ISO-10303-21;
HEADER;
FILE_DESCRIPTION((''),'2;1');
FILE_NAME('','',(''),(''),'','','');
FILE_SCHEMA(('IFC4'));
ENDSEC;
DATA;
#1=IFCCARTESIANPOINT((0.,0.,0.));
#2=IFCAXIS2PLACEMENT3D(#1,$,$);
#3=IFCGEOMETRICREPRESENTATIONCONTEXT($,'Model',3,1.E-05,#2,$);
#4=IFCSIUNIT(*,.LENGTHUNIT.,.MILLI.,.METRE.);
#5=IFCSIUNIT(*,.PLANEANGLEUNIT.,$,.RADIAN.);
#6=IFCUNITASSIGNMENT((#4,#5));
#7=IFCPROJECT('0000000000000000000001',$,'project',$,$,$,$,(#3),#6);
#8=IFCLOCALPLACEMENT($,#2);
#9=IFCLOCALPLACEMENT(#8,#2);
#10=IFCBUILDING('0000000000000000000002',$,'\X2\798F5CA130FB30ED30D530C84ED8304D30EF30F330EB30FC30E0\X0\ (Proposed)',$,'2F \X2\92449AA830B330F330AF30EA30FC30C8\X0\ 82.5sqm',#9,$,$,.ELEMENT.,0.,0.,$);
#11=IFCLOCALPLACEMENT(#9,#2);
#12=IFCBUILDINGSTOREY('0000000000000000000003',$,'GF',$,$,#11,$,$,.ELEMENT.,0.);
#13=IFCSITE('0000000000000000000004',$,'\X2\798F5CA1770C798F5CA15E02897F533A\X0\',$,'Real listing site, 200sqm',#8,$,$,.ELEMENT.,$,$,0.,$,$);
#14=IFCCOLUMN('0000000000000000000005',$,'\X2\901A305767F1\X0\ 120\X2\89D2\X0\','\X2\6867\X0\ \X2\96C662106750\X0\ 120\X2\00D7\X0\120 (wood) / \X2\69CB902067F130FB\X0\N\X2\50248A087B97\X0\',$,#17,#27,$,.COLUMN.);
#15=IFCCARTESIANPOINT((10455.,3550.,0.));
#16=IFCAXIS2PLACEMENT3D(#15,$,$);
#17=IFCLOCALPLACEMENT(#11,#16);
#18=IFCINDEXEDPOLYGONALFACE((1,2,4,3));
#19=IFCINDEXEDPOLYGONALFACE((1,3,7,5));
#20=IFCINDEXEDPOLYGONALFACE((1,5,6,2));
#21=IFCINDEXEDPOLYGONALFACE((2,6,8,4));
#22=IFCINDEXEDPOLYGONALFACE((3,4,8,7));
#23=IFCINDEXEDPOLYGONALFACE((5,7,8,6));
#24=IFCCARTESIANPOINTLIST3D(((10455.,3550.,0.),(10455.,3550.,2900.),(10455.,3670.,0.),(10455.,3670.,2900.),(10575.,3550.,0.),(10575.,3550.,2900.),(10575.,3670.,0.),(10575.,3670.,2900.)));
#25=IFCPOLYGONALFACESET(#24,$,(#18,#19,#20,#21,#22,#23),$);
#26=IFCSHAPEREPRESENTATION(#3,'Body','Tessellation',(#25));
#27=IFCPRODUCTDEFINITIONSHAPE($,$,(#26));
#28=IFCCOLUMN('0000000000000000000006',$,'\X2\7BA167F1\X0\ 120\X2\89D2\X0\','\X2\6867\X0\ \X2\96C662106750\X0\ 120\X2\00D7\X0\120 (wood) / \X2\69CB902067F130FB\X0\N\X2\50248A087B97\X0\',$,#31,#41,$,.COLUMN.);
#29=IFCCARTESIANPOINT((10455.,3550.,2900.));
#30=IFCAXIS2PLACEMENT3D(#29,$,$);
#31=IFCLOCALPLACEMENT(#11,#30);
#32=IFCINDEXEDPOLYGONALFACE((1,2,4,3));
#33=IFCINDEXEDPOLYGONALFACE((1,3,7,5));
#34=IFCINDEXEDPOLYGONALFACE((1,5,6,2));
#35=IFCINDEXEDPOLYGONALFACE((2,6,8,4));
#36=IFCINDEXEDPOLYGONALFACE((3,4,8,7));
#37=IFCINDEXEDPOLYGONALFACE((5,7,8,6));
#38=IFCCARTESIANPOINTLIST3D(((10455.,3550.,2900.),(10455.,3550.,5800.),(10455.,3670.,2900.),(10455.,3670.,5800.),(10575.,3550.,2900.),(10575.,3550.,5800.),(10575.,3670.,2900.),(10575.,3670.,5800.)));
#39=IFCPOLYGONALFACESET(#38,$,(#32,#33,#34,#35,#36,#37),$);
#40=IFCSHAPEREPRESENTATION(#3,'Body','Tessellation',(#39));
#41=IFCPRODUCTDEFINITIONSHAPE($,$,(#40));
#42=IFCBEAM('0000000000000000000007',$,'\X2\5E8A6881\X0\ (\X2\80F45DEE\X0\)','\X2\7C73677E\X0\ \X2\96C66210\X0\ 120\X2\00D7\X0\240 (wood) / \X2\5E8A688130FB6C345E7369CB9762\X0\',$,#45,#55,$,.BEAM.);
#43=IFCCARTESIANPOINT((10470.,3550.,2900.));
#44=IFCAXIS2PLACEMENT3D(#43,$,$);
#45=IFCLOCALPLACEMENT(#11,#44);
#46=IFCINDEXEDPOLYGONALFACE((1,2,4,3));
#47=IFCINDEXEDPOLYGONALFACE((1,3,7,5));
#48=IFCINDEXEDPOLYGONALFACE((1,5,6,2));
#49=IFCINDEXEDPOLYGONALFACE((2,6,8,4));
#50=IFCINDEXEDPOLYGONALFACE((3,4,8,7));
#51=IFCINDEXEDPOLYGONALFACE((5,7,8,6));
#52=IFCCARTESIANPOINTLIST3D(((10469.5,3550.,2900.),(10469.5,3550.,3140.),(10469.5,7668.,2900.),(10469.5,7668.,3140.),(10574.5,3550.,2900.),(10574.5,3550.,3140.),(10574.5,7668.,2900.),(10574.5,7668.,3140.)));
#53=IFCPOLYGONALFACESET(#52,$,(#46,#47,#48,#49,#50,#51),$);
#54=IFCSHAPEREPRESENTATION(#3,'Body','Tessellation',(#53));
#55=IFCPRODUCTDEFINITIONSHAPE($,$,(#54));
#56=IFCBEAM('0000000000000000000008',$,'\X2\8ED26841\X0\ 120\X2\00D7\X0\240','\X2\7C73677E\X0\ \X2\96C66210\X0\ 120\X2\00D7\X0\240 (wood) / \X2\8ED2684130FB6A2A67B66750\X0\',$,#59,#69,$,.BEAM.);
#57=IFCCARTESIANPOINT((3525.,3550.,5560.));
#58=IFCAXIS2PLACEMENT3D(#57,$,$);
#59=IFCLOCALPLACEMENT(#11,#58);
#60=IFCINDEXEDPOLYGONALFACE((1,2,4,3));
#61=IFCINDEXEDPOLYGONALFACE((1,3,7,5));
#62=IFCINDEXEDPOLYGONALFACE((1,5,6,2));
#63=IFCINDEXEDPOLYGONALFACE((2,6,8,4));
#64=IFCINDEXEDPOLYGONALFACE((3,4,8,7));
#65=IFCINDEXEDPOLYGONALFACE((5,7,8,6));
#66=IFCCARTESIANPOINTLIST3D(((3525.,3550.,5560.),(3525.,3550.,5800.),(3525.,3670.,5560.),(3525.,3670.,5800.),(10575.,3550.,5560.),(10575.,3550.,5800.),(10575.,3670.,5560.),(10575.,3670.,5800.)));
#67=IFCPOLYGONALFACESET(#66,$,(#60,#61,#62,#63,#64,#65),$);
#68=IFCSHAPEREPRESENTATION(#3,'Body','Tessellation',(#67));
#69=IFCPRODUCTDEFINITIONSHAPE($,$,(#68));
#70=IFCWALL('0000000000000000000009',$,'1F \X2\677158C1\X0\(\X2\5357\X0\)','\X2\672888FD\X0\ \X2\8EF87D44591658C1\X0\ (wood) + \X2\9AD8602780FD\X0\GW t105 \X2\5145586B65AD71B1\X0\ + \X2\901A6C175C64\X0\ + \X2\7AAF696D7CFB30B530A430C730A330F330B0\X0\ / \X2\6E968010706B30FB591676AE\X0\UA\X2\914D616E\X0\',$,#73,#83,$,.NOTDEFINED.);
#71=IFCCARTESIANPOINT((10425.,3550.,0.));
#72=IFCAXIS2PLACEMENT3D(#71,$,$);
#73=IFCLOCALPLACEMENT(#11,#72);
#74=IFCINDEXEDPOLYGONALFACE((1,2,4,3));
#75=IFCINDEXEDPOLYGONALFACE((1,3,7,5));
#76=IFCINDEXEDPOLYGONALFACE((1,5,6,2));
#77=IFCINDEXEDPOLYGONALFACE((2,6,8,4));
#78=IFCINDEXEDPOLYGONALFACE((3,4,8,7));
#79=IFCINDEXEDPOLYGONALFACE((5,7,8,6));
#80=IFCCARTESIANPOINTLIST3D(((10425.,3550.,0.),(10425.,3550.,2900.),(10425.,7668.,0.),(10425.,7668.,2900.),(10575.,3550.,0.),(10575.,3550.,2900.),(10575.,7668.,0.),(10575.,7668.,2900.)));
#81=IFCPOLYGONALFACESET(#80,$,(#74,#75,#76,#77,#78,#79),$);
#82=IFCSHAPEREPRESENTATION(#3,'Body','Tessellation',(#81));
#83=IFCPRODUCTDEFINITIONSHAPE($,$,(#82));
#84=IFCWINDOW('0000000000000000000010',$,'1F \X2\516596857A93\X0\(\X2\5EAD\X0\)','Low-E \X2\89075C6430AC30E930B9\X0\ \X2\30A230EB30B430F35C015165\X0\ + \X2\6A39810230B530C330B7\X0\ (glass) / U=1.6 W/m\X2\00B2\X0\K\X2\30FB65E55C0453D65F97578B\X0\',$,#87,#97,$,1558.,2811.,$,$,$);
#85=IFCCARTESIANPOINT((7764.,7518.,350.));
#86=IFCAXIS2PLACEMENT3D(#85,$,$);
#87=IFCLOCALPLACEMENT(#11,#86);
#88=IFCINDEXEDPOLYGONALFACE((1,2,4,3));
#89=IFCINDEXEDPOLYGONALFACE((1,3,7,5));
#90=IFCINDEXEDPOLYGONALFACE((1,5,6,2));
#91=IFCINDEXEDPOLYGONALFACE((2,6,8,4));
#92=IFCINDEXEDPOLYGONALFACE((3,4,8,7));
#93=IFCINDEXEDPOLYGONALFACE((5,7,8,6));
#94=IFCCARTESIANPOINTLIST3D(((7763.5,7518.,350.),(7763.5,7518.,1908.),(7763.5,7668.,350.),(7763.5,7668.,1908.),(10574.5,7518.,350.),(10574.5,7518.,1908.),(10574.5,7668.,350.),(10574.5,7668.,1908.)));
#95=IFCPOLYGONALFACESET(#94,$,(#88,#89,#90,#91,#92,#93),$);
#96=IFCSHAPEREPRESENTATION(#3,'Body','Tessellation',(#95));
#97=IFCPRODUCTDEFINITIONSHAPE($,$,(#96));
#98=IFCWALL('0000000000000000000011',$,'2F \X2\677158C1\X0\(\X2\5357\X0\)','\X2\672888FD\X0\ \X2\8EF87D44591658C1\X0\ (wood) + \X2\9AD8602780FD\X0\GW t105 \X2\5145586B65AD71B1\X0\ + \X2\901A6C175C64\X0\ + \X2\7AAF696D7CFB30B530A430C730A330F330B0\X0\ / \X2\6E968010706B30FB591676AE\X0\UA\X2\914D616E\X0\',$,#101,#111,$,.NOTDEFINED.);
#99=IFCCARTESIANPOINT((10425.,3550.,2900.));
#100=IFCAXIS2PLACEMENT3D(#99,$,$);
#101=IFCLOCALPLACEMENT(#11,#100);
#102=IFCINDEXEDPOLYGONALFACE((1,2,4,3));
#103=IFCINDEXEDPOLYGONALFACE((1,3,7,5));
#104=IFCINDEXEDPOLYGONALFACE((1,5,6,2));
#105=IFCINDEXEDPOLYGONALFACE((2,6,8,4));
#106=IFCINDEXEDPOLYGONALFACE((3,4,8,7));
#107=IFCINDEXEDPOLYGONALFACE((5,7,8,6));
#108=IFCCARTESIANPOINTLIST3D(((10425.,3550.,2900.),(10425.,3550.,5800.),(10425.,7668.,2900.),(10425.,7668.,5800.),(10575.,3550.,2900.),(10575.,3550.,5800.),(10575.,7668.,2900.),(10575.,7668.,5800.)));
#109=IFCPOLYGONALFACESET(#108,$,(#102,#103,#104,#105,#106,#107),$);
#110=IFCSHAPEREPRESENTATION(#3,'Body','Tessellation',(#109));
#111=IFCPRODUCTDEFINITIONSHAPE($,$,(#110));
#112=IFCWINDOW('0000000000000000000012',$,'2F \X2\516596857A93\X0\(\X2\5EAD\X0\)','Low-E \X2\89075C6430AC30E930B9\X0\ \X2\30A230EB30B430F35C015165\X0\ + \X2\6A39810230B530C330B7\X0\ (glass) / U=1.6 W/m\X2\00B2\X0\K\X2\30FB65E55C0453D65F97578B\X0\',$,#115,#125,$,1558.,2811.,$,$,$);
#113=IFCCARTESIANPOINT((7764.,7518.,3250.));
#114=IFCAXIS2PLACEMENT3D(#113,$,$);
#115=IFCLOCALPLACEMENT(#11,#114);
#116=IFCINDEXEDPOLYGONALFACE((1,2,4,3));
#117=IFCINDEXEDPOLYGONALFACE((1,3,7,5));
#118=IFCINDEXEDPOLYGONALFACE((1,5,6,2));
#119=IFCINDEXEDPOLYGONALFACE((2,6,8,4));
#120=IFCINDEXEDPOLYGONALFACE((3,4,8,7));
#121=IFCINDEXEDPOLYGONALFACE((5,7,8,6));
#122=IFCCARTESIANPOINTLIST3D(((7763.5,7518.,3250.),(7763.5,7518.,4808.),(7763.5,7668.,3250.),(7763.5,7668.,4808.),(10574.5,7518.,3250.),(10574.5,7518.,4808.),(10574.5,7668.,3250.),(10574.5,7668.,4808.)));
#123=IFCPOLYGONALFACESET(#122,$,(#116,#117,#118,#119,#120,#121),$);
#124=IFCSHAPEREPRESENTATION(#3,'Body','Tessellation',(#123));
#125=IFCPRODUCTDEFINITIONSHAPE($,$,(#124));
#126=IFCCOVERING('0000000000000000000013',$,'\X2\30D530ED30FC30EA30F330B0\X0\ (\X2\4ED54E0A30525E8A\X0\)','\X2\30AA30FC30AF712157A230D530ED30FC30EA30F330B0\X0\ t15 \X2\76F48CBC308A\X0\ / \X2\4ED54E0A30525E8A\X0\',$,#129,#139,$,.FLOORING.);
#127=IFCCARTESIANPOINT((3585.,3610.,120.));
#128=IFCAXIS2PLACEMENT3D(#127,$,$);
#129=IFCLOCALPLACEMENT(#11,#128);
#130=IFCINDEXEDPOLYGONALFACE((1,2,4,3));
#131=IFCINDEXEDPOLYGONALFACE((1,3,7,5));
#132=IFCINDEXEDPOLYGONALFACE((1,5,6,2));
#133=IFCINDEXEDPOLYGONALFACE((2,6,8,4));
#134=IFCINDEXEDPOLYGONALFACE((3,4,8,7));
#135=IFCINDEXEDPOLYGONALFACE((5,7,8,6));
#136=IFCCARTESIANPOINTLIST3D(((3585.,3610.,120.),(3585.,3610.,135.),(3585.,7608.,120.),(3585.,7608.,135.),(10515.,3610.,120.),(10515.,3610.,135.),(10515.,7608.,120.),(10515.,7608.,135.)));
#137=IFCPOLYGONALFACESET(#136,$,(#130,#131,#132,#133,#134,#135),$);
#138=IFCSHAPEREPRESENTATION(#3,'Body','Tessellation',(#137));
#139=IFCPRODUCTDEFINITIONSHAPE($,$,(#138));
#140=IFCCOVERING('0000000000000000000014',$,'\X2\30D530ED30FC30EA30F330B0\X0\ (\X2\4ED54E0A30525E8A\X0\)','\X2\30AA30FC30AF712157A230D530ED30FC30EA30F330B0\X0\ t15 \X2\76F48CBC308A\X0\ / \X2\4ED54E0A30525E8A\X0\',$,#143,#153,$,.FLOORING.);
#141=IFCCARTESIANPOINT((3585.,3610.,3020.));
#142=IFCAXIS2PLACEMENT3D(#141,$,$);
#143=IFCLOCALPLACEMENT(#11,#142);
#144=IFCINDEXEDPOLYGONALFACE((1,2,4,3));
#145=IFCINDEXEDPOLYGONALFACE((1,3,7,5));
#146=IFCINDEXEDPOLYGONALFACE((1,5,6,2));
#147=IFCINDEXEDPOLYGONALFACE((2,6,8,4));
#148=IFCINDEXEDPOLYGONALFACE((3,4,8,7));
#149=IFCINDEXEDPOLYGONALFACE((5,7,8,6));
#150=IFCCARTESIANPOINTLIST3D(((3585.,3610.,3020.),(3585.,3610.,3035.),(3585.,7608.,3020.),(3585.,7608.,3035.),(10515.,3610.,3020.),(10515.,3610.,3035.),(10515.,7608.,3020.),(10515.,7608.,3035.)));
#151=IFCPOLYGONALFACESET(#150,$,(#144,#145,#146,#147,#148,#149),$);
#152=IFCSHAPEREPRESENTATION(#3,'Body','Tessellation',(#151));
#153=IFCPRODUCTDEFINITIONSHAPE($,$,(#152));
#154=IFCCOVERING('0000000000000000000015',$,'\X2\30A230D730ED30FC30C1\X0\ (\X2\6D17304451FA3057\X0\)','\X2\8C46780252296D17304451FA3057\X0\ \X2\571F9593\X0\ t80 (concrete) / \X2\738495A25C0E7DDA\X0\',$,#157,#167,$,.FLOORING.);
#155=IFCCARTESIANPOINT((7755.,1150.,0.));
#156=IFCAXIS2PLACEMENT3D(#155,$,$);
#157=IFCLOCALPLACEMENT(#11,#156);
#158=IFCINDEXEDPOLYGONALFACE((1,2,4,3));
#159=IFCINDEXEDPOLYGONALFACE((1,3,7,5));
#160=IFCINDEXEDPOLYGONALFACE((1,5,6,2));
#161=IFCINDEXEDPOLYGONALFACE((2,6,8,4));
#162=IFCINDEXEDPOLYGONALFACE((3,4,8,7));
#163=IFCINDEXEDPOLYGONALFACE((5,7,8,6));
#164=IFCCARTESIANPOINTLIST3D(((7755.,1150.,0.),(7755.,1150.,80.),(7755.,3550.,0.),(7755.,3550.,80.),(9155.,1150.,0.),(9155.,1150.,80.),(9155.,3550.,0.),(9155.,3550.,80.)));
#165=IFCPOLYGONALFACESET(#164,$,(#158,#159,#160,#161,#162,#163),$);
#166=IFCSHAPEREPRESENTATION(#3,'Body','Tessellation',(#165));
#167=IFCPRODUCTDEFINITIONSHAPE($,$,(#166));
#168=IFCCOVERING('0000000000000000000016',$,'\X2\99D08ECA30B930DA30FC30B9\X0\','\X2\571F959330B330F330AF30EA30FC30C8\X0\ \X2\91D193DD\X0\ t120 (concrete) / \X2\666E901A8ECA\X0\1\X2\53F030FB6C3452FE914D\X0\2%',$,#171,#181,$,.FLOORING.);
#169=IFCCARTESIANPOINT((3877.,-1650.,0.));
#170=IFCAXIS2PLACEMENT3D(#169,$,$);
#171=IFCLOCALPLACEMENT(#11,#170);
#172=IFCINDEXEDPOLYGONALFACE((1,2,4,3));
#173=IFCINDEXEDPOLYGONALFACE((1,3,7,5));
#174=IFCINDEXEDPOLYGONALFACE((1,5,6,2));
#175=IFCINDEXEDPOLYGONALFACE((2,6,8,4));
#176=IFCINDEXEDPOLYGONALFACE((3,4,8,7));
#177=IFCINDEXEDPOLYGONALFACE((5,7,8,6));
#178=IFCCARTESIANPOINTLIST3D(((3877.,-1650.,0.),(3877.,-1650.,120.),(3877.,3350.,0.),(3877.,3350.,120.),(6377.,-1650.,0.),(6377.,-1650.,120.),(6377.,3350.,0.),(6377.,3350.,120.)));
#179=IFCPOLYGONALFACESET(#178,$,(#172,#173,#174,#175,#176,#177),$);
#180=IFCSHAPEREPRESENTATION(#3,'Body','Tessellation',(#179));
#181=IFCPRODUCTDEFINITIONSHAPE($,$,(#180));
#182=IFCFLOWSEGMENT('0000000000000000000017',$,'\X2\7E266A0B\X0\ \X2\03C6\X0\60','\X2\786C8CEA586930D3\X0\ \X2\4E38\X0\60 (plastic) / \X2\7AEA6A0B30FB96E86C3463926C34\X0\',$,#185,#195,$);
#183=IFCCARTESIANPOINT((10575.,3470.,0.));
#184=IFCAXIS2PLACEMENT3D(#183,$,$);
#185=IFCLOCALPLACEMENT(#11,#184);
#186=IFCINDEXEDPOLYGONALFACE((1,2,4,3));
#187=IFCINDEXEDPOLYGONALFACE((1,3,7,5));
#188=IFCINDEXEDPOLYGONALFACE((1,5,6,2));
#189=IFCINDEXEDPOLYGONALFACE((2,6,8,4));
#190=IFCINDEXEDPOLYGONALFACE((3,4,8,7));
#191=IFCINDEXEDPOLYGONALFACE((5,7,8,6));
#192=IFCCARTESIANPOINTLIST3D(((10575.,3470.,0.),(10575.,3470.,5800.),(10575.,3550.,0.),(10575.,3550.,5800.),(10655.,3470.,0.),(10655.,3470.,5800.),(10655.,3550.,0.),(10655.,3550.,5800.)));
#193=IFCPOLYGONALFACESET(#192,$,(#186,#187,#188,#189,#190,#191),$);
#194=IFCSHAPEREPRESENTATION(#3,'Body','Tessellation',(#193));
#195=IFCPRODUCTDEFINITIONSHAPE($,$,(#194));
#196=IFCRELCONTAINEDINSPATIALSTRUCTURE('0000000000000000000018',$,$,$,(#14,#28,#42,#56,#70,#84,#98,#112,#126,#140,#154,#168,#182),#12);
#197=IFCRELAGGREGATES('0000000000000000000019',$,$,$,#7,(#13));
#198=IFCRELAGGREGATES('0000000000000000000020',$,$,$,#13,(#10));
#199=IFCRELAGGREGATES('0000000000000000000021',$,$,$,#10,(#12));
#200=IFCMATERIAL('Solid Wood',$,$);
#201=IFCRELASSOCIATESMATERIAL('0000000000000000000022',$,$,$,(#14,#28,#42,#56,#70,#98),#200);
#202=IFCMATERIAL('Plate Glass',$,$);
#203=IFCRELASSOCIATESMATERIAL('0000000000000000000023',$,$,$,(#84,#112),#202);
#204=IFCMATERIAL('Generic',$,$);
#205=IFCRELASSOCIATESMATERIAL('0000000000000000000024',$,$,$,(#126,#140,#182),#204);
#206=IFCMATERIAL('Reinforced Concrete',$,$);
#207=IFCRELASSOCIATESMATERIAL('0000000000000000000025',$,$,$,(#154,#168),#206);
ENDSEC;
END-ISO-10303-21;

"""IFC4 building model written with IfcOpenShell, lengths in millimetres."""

from ifc_helpers import new_model, si_unit, frame, frame_2d, origin, place, context, project, spatial, rectangle, extrude, material, element, fill, save


model = new_model("IFC4")

# Units and contexts
model_context = context("Model", 3, precision=1e-05, world=origin())
ifc_project = project(units=[si_unit("LENGTHUNIT", "METRE", prefix="MILLI"), si_unit("PLANEANGLEUNIT", "RADIAN")], contexts=[model_context])

# Site, building, storey
site_placement = place(None, origin())
site = spatial("IfcSite", under=ifc_project, at=site_placement, Name="福岡県福岡市西区", ObjectType="Real listing site, 200sqm", CompositionType="ELEMENT", RefElevation=0.0)
building_placement = place(site_placement, origin())
building = spatial("IfcBuilding", under=site, at=building_placement, Name="福岡・ロフト付きワンルーム (Proposed)", ObjectType="2F 鉄骨コンクリート 82.5sqm", CompositionType="ELEMENT", ElevationOfRefHeight=0.0, ElevationOfTerrain=0.0)
storey_placement = place(building_placement, origin())
storey = spatial("IfcBuildingStorey", under=building, at=storey_placement, Name="GF", CompositionType="ELEMENT", Elevation=0.0)

# Columns
ifc_material_1 = material(Name="Solid Wood")
column_1_placement = place(storey_placement, frame((10455.0, 3550.0, 0.0)))
element("IfcColumn", 1, at=column_1_placement, inside=storey, material=ifc_material_1, Name="通し柱 120角", Description="桧 集成材 120×120 (wood) / 構造柱・N値計算", PredefinedType="COLUMN", context=model_context, shape_type="SweptSolid", body=[
    extrude(rectangle(XDim=120.0, YDim=120.0, at=frame_2d((60.0, 60.0))), frame((10455.0, 3550.0, 0.0)), (0.0, 0.0, 1.0), 2900.0),
])
column_2_placement = place(storey_placement, frame((10455.0, 3550.0, 2900.0)))
element("IfcColumn", 2, at=column_2_placement, inside=storey, material=ifc_material_1, Name="管柱 120角", Description="桧 集成材 120×120 (wood) / 構造柱・N値計算", PredefinedType="COLUMN", context=model_context, shape_type="SweptSolid", body=[
    extrude(rectangle(XDim=120.0, YDim=120.0, at=frame_2d((60.0, 60.0))), frame((10455.0, 3550.0, 2900.0)), (0.0, 0.0, 1.0), 2900.0),
])

# Beams
beam_1_placement = place(storey_placement, frame((10470.0, 3550.0, 2900.0)))
element("IfcBeam", 3, at=beam_1_placement, inside=storey, material=ifc_material_1, Name="床梁 (胴差)", Description="米松 集成 120×240 (wood) / 床梁・水平構面", PredefinedType="BEAM", context=model_context, shape_type="SweptSolid", body=[
    extrude(rectangle(XDim=105.0, YDim=4118.0, at=frame_2d((52.0, 2059.0))), frame((10470.0, 3550.0, 2900.0)), (0.0, 0.0, 1.0), 240.0),
])
beam_2_placement = place(storey_placement, frame((3525.0, 3550.0, 5560.0)))
element("IfcBeam", 4, at=beam_2_placement, inside=storey, material=ifc_material_1, Name="軒桁 120×240", Description="米松 集成 120×240 (wood) / 軒桁・横架材", PredefinedType="BEAM", context=model_context, shape_type="SweptSolid", body=[
    extrude(rectangle(XDim=7050.0, YDim=120.0, at=frame_2d((3525.0, 60.0))), frame((3525.0, 3550.0, 5560.0)), (0.0, 0.0, 1.0), 240.0),
])

# Wall, opening, window
wall_1_placement = place(storey_placement, frame((10425.0, 3550.0, 0.0)))
wall_1 = element("IfcWall", 5, at=wall_1_placement, inside=storey, material=ifc_material_1, Name="1F 東壁(南)", Description="木製 軸組外壁 (wood) + 高性能GW t105 充填断熱 + 通気層 + 窯業系サイディング / 準耐火・外皮UA配慮", PredefinedType="NOTDEFINED", context=model_context, shape_type="SweptSolid", body=[
    extrude(rectangle(XDim=150.0, YDim=4118.0, at=frame_2d((75.0, 2059.0))), frame((10425.0, 3550.0, 0.0)), (0.0, 0.0, 1.0), 2900.0),
])
opening_1_placement = place(storey_placement, frame((7764.0, 7518.0, 350.0)))
opening_1 = element("IfcOpeningElement", 6, at=opening_1_placement, cuts=wall_1, PredefinedType="NOTDEFINED", context=model_context, shape_type="SweptSolid", body=[
    extrude(rectangle(XDim=2811.0, YDim=150.0, at=frame_2d((1405.0, 75.0))), frame((7764.0, 7518.0, 350.0)), (0.0, 0.0, 1.0), 1558.0),
])
ifc_material_2 = material(Name="Plate Glass")
window_1_placement = place(storey_placement, frame((7764.0, 7518.0, 350.0)))
window_1 = element("IfcWindow", 7, at=window_1_placement, inside=storey, material=ifc_material_2, Name="1F 入隅窓(庭)", Description="Low-E 複層ガラス アルゴン封入 + 樹脂サッシ (glass) / U=1.6 W/m²K・日射取得型", OverallHeight=1558.0, OverallWidth=2811.0, context=model_context, shape_type="SweptSolid", body=[
    extrude(rectangle(XDim=2811.0, YDim=150.0, at=frame_2d((1405.0, 75.0))), frame((7764.0, 7518.0, 350.0)), (0.0, 0.0, 1.0), 1558.0),
])
fill(opening_1, window_1)

# Wall, opening, window
wall_2_placement = place(storey_placement, frame((10425.0, 3550.0, 2900.0)))
wall_2 = element("IfcWall", 8, at=wall_2_placement, inside=storey, material=ifc_material_1, Name="2F 東壁(南)", Description="木製 軸組外壁 (wood) + 高性能GW t105 充填断熱 + 通気層 + 窯業系サイディング / 準耐火・外皮UA配慮", PredefinedType="NOTDEFINED", context=model_context, shape_type="SweptSolid", body=[
    extrude(rectangle(XDim=150.0, YDim=4118.0, at=frame_2d((75.0, 2059.0))), frame((10425.0, 3550.0, 2900.0)), (0.0, 0.0, 1.0), 2900.0),
])
opening_2_placement = place(storey_placement, frame((7764.0, 7518.0, 3250.0)))
opening_2 = element("IfcOpeningElement", 9, at=opening_2_placement, cuts=wall_2, PredefinedType="NOTDEFINED", context=model_context, shape_type="SweptSolid", body=[
    extrude(rectangle(XDim=2811.0, YDim=150.0, at=frame_2d((1405.0, 75.0))), frame((7764.0, 7518.0, 3250.0)), (0.0, 0.0, 1.0), 1558.0),
])
window_2_placement = place(storey_placement, frame((7764.0, 7518.0, 3250.0)))
window_2 = element("IfcWindow", 10, at=window_2_placement, inside=storey, material=ifc_material_2, Name="2F 入隅窓(庭)", Description="Low-E 複層ガラス アルゴン封入 + 樹脂サッシ (glass) / U=1.6 W/m²K・日射取得型", OverallHeight=1558.0, OverallWidth=2811.0, context=model_context, shape_type="SweptSolid", body=[
    extrude(rectangle(XDim=2811.0, YDim=150.0, at=frame_2d((1405.0, 75.0))), frame((7764.0, 7518.0, 3250.0)), (0.0, 0.0, 1.0), 1558.0),
])
fill(opening_2, window_2)

# Coverings
ifc_material_3 = material(Name="Generic")
covering_1_placement = place(storey_placement, frame((3585.0, 3610.0, 120.0)))
element("IfcCovering", 11, at=covering_1_placement, inside=storey, material=ifc_material_3, Name="フローリング (仕上げ床)", Description="オーク無垢フローリング t15 直貼り / 仕上げ床", PredefinedType="FLOORING", context=model_context, shape_type="SweptSolid", body=[
    extrude(rectangle(XDim=6930.0, YDim=3998.0, at=frame_2d((3465.0, 1999.0))), frame((3585.0, 3610.0, 120.0)), (0.0, 0.0, 1.0), 15.0),
])
covering_2_placement = place(storey_placement, frame((3585.0, 3610.0, 3020.0)))
element("IfcCovering", 12, at=covering_2_placement, inside=storey, material=ifc_material_3, Name="フローリング (仕上げ床)", Description="オーク無垢フローリング t15 直貼り / 仕上げ床", PredefinedType="FLOORING", context=model_context, shape_type="SweptSolid", body=[
    extrude(rectangle(XDim=6930.0, YDim=3998.0, at=frame_2d((3465.0, 1999.0))), frame((3585.0, 3610.0, 3020.0)), (0.0, 0.0, 1.0), 15.0),
])
ifc_material_4 = material(Name="Reinforced Concrete")
covering_3_placement = place(storey_placement, frame((7755.0, 1150.0, 0.0)))
element("IfcCovering", 13, at=covering_3_placement, inside=storey, material=ifc_material_4, Name="アプローチ (洗い出し)", Description="豆砂利洗い出し 土間 t80 (concrete) / 玄関導線", PredefinedType="FLOORING", context=model_context, shape_type="SweptSolid", body=[
    extrude(rectangle(XDim=1400.0, YDim=2400.0, at=frame_2d((700.0, 1200.0))), frame((7755.0, 1150.0, 0.0)), (0.0, 0.0, 1.0), 80.0),
])
covering_4_placement = place(storey_placement, frame((3877.0, -1650.0, 0.0)))
element("IfcCovering", 14, at=covering_4_placement, inside=storey, material=ifc_material_4, Name="駐車スペース", Description="土間コンクリート 金鏝 t120 (concrete) / 普通車1台・水勾配2%", PredefinedType="FLOORING", context=model_context, shape_type="SweptSolid", body=[
    extrude(rectangle(XDim=2500.0, YDim=5000.0, at=frame_2d((1250.0, 2500.0))), frame((3877.0, -1650.0, 0.0)), (0.0, 0.0, 1.0), 120.0),
])

# Flow segment
flow_segment_placement = place(storey_placement, frame((10575.0, 3470.0, 0.0)))
element("IfcFlowSegment", 15, at=flow_segment_placement, inside=storey, material=ifc_material_3, Name="縦樋 φ60", Description="硬質塩ビ 丸60 (plastic) / 竪樋・雨水排水", context=model_context, shape_type="SweptSolid", body=[
    extrude(rectangle(XDim=80.0, YDim=80.0, at=frame_2d((40.0, 40.0))), frame((10575.0, 3470.0, 0.0)), (0.0, 0.0, 1.0), 5800.0),
])

save(model, "model.ifc")
